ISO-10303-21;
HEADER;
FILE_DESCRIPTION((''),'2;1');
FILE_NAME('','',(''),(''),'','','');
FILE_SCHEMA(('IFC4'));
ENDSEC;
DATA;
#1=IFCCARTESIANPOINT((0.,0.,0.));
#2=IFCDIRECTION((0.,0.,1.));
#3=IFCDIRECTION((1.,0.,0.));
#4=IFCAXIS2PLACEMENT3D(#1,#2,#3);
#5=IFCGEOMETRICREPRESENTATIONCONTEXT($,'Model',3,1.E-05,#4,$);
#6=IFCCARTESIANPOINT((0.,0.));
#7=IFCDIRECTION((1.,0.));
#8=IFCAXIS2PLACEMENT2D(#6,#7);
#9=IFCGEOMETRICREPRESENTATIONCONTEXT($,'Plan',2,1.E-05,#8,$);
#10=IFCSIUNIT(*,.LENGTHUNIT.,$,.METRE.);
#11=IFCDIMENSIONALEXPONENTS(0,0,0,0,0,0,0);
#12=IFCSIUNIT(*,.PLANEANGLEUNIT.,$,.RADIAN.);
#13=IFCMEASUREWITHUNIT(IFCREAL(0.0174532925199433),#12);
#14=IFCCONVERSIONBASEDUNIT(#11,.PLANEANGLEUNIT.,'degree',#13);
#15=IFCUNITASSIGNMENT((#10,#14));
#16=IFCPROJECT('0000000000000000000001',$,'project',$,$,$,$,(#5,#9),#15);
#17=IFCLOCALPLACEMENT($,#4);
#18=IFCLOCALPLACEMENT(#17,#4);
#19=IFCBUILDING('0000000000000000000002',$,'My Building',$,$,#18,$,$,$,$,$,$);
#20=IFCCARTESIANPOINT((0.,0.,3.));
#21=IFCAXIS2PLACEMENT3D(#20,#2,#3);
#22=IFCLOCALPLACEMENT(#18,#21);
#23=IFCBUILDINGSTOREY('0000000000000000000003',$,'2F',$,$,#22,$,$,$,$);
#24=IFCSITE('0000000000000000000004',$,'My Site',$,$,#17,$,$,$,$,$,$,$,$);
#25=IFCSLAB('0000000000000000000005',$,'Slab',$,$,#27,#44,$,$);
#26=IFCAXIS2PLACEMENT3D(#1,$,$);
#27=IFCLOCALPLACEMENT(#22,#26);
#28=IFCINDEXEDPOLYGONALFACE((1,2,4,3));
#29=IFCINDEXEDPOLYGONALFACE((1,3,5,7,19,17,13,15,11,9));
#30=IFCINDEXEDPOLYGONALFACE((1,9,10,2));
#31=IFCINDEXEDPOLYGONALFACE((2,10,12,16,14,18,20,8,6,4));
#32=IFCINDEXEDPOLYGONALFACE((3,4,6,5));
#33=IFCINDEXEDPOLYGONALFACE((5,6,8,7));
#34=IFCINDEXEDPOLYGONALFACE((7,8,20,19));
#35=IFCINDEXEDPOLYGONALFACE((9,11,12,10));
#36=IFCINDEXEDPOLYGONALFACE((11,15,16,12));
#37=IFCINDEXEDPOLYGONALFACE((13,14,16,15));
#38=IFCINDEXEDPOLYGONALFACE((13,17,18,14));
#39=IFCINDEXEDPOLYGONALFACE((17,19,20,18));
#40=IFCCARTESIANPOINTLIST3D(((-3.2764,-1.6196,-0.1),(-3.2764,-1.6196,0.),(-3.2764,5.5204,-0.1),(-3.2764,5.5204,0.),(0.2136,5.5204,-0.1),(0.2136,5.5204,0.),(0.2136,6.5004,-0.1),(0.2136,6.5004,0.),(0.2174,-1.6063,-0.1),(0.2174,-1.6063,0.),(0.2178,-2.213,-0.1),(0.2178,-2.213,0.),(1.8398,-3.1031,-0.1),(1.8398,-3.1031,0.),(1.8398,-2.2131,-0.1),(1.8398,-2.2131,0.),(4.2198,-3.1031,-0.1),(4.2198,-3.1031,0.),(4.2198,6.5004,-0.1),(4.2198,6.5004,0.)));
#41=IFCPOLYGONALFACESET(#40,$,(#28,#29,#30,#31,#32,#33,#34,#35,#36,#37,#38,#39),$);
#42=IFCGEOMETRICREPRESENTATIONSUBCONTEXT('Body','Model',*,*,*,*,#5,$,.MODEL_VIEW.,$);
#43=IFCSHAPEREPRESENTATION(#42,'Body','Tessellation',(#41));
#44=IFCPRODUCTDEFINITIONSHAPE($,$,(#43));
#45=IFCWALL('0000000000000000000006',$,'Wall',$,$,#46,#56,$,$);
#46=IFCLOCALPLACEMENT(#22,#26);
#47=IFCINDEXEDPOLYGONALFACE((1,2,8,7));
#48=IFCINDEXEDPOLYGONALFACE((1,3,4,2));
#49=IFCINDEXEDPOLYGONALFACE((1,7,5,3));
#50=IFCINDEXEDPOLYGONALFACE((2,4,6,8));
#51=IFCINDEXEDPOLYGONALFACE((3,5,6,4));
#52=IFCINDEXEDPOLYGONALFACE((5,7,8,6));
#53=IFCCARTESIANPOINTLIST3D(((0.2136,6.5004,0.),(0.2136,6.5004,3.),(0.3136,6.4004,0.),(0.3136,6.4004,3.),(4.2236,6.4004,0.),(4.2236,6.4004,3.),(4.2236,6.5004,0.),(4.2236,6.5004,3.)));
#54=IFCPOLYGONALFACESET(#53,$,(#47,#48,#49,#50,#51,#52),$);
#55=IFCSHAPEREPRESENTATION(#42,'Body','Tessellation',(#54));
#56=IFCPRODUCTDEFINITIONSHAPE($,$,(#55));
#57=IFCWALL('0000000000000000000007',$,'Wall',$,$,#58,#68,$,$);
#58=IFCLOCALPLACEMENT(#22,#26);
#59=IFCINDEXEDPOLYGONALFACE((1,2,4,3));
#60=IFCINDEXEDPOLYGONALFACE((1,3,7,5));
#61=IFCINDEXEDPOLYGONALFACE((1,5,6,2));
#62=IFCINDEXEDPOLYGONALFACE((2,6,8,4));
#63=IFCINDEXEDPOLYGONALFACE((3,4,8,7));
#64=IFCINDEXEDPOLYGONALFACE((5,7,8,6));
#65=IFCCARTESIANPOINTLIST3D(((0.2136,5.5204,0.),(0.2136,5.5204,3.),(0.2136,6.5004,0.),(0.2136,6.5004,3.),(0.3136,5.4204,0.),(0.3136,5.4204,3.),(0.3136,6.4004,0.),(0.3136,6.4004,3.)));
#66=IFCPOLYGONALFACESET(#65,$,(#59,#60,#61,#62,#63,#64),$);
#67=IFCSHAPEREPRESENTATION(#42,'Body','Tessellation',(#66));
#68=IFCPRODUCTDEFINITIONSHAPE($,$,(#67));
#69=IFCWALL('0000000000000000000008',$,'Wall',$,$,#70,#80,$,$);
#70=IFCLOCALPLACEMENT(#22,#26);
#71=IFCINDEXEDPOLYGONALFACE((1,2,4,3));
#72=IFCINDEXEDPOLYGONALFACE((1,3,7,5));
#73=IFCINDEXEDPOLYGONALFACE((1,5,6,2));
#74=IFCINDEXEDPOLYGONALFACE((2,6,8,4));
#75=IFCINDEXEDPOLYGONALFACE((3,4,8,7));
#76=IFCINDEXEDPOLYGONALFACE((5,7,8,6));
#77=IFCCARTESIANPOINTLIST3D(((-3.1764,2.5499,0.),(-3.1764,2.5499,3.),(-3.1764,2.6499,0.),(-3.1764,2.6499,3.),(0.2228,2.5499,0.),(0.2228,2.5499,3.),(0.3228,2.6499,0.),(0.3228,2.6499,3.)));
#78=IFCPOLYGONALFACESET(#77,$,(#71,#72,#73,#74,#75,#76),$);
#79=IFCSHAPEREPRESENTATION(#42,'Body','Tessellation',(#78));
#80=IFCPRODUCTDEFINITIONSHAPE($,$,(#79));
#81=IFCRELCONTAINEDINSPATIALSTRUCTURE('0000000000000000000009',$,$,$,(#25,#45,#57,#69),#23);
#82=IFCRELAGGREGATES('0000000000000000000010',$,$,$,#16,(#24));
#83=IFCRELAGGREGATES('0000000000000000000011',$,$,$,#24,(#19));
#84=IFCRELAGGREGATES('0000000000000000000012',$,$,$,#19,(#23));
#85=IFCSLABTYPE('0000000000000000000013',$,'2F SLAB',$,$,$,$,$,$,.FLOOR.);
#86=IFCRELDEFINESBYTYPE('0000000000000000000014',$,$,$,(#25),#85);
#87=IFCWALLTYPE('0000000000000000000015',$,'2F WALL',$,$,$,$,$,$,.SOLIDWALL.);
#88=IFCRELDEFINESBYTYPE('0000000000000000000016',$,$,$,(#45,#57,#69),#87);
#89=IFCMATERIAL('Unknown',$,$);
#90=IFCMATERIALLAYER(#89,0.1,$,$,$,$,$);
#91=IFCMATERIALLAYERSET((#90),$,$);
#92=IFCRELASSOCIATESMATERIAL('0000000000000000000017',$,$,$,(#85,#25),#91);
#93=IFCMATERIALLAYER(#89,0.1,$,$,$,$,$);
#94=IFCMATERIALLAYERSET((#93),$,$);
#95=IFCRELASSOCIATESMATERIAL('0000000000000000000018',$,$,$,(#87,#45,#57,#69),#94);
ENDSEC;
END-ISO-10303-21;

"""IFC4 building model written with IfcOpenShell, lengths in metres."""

from ifc_helpers import new_model, entity, si_unit, converted_unit, frame, origin_with_axes, origin_2d_with_axis, place, context, subcontext, project, spatial, line, indexed_curve, outline, extrude, material, layer, layer_set, layer_usage, type_object, element, save


model = new_model("IFC4")

# Units and contexts
model_context = context("Model", 3, precision=1e-05, world=origin_with_axes())
plan_context = context("Plan", 2, precision=1e-05, world=origin_2d_with_axis())
body_context_1 = subcontext(model_context, "Body", "Model", "MODEL_VIEW")
ifc_project = project(units=[si_unit("LENGTHUNIT", "METRE"), converted_unit("PLANEANGLEUNIT", "degree", entity("IfcReal", 0.0174532925199433), si_unit("PLANEANGLEUNIT", "RADIAN"), dimensions=[0, 0, 0, 0, 0, 0, 0])], contexts=[model_context, plan_context])

# Site, building, storey
site_placement = place(None, origin_with_axes())
site = spatial("IfcSite", under=ifc_project, at=site_placement, Name="My Site")
building_placement = place(site_placement, origin_with_axes())
building = spatial("IfcBuilding", under=site, at=building_placement, Name="My Building")
storey_placement = place(building_placement, frame((0.0, 0.0, 3.0), z_axis=(0.0, 0.0, 1.0), x_axis=(1.0, 0.0, 0.0)))
storey = spatial("IfcBuildingStorey", under=building, at=storey_placement, Name="2F")

# Slab
ifc_material = material(Name="Unknown")
ifc_layer_1 = layer(ifc_material, 0.1)
ifc_layer_set_1 = layer_set([ifc_layer_1])
ifc_layer_usage_1 = layer_usage(ifc_layer_set_1, "AXIS3", "POSITIVE", -0.1)
slab_type = type_object("IfcSlabType", Name="2F SLAB", PredefinedType="FLOOR", material=ifc_layer_set_1)
slab_placement = place(storey_placement, frame((4.2198, 6.5004, 0.0), z_axis=(0.0, 0.0, 1.0), x_axis=(1.0, 0.0, 0.0)))
element("IfcSlab", 1, at=slab_placement, inside=storey, type_object=slab_type, material=ifc_layer_usage_1, Name="Slab", context=body_context_1, shape_type="SweptSolid", body=[
    extrude(outline(indexed_curve([(0.0, 0.0), (0.0, -9.6034), (-2.38, -9.6034), (-2.38, -8.7134), (-4.002, -8.7134), (-4.0024, -8.1067), (-7.4963, -8.12), (-7.4963, -0.98), (-4.0063, -0.98), (-4.0063, 0.0), (0.0, 0.0)])), frame((0.0, 0.0, -0.1), z_axis=(0.0, 0.0, 1.0), x_axis=(1.0, 0.0, 0.0)), (0.0, 0.0, 1.0), 0.1),
])

# Walls
ifc_layer_2 = layer(ifc_material, 0.1)
ifc_layer_set_2 = layer_set([ifc_layer_2])
ifc_layer_usage_2 = layer_usage(ifc_layer_set_2, "AXIS2", "POSITIVE", 0.0)
wall_type = type_object("IfcWallType", Name="2F WALL", PredefinedType="SOLIDWALL", material=ifc_layer_set_2)
wall_1_placement = place(storey_placement, frame((4.2236, 6.5004, 0.0), z_axis=(0.0, 0.0, 1.0), x_axis=(-1.0, 0.0, 0.0)))
element("IfcWall", 2, at=wall_1_placement, inside=storey, type_object=wall_type, material=ifc_layer_usage_2, Name="Wall", context=body_context_1, shape_type="SweptSolid", body=[
    extrude(outline(indexed_curve([(0.0, 0.0), (0.0, 0.1), (3.91, 0.1), (4.01, 0.0)], segments=[line(1, 2, 3, 4, 1)])), origin_with_axes(), (0.0, 0.0, 1.0), 3.0),
])
ifc_layer_usage_3 = layer_usage(ifc_layer_set_2, "AXIS2", "POSITIVE", 0.0)
wall_2_placement = place(storey_placement, frame((0.2136, 6.5004, 0.0), z_axis=(0.0, 0.0, 1.0), x_axis=(0.0, -1.0, 0.0)))
element("IfcWall", 3, at=wall_2_placement, inside=storey, type_object=wall_type, material=ifc_layer_usage_3, Name="Wall", context=body_context_1, shape_type="SweptSolid", body=[
    extrude(outline(indexed_curve([(0.0, 0.0), (0.1, 0.1), (1.08, 0.1), (0.98, 0.0)], segments=[line(1, 2, 3, 4, 1)])), origin_with_axes(), (0.0, 0.0, 1.0), 3.0),
])

# Wall
ifc_layer_usage_4 = layer_usage(ifc_layer_set_2, "AXIS2", "POSITIVE", 0.0)
wall_3_placement = place(storey_placement, frame((0.3228, 2.6499, 0.0), z_axis=(0.0, 0.0, 1.0), x_axis=(-1.0, 0.0, 0.0)))
element("IfcWall", 4, at=wall_3_placement, inside=storey, type_object=wall_type, material=ifc_layer_usage_4, Name="Wall", context=body_context_1, shape_type="SweptSolid", body=[
    extrude(outline(indexed_curve([(0.0, 0.0), (0.1, 0.1), (3.4992, 0.1), (3.4992, 0.0)], segments=[line(1, 2, 3, 4, 1)])), origin_with_axes(), (0.0, 0.0, 1.0), 3.0),
])

save(model, "model.ifc")
